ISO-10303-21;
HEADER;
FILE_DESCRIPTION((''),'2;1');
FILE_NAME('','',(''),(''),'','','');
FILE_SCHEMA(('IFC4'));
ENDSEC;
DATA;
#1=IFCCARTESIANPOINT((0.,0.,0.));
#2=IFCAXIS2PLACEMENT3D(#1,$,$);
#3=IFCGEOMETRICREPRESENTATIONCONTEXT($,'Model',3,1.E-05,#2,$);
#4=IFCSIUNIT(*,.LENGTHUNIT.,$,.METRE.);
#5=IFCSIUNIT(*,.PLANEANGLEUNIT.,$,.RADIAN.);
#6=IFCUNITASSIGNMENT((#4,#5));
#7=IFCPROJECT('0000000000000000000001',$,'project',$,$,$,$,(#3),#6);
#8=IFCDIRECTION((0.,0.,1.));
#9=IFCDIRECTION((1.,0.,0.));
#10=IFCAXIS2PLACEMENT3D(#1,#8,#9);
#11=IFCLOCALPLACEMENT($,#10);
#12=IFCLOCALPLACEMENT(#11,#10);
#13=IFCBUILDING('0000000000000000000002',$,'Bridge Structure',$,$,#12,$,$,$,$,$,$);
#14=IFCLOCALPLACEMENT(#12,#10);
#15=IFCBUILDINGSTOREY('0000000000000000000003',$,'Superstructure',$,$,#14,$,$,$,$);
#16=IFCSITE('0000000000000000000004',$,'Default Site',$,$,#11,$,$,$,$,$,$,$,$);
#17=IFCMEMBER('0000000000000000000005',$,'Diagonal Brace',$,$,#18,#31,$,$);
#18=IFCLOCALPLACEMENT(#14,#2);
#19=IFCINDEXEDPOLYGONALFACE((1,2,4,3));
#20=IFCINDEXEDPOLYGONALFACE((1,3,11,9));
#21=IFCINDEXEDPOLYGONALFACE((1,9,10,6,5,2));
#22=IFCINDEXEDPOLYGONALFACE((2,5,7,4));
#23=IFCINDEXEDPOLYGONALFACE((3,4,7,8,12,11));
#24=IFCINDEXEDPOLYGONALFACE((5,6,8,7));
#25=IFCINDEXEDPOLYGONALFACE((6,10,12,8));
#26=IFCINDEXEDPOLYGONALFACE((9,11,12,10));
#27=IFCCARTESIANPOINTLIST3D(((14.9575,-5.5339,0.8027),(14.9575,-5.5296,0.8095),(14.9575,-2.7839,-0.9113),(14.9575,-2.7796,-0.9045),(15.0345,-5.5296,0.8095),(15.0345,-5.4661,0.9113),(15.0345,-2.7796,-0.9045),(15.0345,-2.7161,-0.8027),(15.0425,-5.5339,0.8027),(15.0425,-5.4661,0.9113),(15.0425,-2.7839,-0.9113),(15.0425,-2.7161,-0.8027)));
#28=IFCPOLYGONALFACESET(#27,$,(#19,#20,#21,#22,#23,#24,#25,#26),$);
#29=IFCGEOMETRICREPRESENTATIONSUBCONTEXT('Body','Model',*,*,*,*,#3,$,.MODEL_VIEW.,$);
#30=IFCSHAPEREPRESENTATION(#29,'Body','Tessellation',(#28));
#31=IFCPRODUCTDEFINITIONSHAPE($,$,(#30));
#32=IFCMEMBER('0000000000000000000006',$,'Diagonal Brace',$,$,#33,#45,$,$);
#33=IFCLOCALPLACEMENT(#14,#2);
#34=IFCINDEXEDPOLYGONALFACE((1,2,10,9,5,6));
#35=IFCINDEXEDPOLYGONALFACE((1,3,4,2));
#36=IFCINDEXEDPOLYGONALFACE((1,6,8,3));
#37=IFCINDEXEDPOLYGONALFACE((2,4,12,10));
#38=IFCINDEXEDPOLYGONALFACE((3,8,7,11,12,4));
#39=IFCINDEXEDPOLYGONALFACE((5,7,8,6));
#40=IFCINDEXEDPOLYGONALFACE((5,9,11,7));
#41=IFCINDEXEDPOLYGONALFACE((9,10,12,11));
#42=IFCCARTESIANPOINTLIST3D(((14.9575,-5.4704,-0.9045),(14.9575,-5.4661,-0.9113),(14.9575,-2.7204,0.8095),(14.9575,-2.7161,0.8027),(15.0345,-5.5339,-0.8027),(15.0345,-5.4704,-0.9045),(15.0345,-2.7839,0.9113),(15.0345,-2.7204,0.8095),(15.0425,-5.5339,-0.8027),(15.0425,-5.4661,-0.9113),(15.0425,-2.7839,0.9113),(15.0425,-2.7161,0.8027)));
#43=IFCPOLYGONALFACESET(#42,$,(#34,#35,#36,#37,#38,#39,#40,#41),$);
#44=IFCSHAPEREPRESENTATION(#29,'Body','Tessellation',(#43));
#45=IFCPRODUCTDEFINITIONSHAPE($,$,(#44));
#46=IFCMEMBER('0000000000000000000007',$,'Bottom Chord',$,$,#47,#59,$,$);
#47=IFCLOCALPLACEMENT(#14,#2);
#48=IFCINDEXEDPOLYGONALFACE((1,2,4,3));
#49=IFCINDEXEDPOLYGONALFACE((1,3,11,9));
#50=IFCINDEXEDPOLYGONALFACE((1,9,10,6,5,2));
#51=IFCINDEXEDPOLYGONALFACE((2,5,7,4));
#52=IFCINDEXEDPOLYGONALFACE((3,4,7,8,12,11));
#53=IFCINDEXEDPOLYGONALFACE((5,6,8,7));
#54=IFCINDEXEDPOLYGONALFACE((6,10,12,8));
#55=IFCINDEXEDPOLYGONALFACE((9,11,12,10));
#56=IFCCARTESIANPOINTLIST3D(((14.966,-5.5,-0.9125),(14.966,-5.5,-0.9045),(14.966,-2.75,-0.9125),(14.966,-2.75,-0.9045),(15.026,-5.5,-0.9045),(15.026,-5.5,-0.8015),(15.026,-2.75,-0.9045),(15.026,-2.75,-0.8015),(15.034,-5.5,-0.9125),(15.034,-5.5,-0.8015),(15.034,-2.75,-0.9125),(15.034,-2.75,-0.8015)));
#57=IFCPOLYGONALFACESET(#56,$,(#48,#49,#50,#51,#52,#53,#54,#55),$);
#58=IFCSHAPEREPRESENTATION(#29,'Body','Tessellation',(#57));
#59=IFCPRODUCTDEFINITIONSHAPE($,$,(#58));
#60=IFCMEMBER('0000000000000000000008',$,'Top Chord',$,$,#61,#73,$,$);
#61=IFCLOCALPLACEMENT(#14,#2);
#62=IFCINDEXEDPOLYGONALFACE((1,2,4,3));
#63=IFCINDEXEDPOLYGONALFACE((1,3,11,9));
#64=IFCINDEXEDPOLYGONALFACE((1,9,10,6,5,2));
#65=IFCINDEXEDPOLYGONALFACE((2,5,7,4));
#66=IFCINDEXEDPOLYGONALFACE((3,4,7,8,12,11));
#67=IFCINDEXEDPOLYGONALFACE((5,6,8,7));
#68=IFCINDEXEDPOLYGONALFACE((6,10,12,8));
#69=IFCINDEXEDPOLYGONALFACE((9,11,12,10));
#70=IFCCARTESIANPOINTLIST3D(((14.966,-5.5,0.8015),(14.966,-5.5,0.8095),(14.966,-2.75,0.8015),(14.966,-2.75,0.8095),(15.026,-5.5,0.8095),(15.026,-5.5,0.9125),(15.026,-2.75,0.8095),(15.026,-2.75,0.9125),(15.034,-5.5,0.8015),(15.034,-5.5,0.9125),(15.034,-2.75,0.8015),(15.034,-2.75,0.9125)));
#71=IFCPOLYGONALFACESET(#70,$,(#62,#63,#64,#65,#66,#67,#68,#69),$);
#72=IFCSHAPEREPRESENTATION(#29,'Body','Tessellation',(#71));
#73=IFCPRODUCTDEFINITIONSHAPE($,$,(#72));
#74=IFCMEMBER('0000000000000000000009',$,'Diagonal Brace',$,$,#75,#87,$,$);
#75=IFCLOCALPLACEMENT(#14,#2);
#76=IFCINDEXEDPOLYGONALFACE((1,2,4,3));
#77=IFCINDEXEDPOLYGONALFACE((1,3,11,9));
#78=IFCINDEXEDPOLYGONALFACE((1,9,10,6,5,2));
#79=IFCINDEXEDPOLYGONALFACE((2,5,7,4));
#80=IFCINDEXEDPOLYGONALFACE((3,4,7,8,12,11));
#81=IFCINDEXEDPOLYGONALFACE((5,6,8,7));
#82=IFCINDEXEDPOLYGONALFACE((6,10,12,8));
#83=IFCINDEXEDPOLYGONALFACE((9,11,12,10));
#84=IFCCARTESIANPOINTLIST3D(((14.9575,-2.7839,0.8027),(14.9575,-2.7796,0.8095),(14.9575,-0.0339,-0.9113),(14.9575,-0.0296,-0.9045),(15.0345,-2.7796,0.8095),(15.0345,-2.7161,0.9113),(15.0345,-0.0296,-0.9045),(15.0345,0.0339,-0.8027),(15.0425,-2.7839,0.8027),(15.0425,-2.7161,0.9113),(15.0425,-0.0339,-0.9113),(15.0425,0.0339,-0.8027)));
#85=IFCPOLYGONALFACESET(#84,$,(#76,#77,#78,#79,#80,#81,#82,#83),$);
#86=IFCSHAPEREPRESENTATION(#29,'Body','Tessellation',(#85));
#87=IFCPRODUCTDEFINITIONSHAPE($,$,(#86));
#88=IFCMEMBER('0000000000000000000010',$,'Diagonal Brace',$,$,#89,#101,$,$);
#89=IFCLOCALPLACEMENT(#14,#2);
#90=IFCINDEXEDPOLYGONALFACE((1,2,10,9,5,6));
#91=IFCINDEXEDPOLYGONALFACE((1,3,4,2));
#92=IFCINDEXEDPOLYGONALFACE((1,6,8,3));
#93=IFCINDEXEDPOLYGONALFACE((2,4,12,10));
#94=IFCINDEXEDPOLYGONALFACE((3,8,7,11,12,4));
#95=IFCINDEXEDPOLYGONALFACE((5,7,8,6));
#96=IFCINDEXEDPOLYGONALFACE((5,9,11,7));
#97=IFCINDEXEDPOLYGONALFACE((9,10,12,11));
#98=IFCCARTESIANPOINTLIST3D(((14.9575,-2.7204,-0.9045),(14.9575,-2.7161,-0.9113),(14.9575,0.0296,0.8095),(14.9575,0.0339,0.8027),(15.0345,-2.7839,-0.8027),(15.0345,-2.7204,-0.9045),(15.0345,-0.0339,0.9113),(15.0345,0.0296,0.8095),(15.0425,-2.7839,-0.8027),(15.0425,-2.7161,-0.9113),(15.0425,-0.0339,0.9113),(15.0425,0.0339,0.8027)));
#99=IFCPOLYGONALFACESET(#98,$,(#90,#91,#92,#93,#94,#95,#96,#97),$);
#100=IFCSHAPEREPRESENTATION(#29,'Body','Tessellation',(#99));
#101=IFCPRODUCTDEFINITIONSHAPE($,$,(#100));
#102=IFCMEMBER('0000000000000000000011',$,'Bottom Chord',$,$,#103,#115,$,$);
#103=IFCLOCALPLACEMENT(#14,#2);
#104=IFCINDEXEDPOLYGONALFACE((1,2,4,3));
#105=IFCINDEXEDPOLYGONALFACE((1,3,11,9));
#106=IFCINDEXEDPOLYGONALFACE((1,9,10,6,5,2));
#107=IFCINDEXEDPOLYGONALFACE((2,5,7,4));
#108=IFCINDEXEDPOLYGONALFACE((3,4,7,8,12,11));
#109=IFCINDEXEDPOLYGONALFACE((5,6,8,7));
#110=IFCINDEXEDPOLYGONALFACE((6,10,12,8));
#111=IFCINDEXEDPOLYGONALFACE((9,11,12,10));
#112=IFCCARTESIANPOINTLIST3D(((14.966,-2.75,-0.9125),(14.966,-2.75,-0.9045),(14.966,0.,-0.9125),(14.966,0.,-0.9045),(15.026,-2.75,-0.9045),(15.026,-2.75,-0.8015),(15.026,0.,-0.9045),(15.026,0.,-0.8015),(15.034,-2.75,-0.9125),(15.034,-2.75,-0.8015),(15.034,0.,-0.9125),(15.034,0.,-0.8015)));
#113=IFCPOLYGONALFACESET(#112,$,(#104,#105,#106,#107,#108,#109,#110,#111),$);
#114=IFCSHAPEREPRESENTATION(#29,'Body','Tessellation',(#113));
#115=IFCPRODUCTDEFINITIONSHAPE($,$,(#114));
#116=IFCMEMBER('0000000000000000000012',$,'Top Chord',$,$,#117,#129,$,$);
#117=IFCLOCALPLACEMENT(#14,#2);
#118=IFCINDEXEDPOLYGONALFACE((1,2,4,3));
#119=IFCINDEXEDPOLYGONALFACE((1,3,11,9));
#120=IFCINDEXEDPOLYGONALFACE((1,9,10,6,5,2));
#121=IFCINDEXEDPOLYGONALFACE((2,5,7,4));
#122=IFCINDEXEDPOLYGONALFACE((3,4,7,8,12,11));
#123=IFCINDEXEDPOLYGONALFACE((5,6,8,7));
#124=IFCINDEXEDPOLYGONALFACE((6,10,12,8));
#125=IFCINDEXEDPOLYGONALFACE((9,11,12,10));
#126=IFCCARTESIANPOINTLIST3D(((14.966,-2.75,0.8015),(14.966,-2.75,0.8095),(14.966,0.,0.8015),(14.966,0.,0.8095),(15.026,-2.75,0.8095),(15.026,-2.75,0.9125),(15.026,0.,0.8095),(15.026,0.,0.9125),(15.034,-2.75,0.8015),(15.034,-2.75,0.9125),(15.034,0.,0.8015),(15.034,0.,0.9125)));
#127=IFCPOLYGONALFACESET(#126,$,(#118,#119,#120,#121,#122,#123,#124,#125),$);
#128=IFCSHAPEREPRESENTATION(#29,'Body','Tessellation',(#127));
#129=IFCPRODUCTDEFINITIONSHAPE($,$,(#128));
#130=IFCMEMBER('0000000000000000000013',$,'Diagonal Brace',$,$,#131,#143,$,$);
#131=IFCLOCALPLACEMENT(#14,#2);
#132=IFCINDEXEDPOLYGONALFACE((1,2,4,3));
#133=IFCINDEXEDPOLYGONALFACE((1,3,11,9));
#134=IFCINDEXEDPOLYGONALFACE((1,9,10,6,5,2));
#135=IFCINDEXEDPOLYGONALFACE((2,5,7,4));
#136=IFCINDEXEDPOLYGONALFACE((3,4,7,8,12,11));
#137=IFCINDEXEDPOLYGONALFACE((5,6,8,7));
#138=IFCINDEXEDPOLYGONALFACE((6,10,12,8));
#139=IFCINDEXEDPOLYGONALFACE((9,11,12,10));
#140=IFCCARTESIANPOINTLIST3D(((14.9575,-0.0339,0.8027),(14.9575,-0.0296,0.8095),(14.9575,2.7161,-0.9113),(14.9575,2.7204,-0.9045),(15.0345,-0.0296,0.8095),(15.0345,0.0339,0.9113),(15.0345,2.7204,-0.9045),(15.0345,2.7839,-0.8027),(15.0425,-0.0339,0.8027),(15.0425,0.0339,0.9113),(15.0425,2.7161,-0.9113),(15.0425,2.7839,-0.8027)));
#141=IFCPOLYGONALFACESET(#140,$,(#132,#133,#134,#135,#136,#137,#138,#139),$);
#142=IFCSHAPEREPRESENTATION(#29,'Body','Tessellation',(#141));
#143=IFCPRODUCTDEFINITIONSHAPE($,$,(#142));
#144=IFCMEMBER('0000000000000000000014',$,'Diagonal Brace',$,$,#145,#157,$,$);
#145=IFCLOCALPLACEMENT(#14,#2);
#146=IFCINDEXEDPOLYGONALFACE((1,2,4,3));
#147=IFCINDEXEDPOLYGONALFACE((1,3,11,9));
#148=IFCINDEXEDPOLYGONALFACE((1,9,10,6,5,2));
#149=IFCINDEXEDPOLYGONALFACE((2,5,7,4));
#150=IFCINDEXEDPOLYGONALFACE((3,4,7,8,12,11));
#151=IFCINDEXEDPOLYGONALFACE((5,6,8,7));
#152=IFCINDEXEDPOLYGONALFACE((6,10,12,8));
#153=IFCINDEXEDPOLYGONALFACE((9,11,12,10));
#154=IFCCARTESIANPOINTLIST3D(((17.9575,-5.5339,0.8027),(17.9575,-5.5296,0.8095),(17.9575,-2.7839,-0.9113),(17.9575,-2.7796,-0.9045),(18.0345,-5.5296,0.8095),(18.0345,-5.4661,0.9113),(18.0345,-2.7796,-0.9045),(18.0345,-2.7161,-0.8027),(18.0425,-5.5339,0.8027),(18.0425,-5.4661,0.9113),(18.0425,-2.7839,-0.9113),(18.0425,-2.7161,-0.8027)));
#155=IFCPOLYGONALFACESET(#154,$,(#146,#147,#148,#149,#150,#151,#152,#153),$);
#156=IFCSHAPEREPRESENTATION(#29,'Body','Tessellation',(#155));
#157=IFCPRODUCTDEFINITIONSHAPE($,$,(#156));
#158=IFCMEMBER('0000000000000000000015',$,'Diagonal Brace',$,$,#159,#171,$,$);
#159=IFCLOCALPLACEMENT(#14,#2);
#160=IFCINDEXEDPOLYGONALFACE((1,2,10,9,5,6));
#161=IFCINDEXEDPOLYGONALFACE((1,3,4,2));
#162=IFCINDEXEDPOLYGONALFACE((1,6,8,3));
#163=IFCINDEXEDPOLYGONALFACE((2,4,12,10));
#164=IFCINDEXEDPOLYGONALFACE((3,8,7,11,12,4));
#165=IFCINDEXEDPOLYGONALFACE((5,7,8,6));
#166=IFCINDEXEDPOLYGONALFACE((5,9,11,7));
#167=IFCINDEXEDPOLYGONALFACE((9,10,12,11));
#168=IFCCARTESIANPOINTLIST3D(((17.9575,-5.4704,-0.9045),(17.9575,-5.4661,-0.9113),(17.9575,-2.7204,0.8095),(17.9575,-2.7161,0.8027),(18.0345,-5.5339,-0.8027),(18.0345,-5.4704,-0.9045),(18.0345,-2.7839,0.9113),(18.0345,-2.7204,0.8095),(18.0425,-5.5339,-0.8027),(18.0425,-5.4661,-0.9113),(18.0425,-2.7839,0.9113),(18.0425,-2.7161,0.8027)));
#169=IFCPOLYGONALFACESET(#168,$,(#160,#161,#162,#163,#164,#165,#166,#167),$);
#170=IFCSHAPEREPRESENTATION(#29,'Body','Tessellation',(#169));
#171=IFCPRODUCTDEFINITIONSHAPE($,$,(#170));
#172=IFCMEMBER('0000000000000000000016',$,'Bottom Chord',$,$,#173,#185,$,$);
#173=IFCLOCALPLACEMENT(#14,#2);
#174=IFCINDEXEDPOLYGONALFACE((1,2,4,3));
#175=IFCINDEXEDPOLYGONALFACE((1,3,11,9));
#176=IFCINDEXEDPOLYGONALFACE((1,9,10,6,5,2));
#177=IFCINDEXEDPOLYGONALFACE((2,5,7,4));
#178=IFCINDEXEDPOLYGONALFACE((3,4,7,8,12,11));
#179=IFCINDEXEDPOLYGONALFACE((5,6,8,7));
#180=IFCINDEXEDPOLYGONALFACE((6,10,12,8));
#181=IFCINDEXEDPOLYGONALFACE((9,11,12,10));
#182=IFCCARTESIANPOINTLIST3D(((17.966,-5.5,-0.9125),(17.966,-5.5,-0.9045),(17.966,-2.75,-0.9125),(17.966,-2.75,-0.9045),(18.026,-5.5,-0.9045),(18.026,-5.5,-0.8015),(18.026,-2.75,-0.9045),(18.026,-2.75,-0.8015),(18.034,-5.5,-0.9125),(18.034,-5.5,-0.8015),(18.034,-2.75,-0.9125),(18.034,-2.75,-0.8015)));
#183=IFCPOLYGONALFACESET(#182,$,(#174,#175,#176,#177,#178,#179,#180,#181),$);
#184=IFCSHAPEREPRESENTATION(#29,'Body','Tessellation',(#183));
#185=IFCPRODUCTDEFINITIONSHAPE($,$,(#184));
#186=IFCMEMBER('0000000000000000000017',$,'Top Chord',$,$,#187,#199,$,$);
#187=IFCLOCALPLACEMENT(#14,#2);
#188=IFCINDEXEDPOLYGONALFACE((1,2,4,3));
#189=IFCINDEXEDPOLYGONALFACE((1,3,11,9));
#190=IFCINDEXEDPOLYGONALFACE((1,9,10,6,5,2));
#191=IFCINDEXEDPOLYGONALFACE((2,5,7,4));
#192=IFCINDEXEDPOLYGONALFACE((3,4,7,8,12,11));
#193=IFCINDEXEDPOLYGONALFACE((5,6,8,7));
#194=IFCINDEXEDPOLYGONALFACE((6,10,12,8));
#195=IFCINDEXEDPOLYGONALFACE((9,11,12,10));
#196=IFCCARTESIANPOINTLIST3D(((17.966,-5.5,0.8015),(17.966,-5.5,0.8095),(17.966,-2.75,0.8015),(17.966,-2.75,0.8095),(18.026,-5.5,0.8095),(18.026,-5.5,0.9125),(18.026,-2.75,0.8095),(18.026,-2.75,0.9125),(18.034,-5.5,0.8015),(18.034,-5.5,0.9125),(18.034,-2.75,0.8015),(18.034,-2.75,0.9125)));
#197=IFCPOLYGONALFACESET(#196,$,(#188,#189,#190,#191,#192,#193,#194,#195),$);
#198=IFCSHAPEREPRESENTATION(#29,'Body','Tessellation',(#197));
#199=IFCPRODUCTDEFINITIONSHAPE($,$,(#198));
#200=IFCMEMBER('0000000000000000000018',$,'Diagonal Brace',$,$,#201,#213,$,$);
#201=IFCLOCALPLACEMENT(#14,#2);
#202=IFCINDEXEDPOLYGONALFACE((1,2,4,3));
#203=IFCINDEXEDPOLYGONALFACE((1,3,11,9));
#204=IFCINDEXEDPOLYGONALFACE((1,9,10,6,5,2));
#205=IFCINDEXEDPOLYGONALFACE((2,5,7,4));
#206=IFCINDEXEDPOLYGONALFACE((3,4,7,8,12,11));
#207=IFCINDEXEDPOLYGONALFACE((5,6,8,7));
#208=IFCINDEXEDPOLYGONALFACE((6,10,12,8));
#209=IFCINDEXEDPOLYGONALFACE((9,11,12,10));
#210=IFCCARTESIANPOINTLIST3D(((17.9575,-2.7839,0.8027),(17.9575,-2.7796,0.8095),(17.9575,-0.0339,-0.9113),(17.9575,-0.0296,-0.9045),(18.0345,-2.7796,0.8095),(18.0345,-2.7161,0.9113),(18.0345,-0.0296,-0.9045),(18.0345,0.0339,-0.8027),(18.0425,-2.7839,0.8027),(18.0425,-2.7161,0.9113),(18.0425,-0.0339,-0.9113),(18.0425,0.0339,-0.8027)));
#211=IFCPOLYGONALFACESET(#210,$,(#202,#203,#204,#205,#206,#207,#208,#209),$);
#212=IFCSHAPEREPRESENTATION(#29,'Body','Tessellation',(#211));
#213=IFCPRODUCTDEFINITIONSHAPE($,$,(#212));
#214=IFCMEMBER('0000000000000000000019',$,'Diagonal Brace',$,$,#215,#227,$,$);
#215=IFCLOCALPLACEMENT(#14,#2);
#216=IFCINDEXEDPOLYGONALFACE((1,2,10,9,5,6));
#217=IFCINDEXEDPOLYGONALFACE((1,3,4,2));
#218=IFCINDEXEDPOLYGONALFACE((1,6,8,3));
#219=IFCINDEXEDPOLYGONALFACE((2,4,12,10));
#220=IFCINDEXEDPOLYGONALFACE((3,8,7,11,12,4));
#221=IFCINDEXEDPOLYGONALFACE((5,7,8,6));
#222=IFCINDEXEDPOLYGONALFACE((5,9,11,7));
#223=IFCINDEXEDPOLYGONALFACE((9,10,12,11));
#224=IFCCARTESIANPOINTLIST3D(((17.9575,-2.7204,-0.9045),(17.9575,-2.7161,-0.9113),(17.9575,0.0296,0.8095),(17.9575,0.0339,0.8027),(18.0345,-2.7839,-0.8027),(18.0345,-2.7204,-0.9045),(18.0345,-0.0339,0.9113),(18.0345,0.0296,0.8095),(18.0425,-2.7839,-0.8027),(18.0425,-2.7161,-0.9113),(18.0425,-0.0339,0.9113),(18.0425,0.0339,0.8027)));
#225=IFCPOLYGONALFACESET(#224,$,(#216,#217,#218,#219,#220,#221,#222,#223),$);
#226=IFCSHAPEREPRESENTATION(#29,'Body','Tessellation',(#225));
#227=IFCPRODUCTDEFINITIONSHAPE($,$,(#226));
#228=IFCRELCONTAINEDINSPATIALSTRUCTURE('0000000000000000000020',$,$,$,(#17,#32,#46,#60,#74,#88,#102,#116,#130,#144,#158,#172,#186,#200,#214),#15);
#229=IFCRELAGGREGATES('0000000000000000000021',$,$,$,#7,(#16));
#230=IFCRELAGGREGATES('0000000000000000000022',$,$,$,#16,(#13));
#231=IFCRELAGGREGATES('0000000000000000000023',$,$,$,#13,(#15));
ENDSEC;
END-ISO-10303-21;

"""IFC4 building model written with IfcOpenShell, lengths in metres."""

from ifc_helpers import new_model, si_unit, frame, origin, origin_with_axes, origin_2d_with_axis, place, context, subcontext, project, spatial, l_section, extrude, element, save


model = new_model("IFC4")

# Units and contexts
model_context = context("Model", 3, precision=1e-05, world=origin())
body_context = subcontext(model_context, "Body", "Model", "MODEL_VIEW")
ifc_project = project(units=[si_unit("LENGTHUNIT", "METRE"), si_unit("PLANEANGLEUNIT", "RADIAN")], contexts=[model_context])

# Site, building, storey
site_placement = place(None, origin_with_axes())
site = spatial("IfcSite", under=ifc_project, at=site_placement, Name="Default Site")
building_placement = place(site_placement, origin_with_axes())
building = spatial("IfcBuilding", under=site, at=building_placement, Name="Bridge Structure")
storey_placement = place(building_placement, origin_with_axes())
storey = spatial("IfcBuildingStorey", under=building, at=storey_placement, Name="Superstructure")

# Members
for number, where, z_axis, x_axis, name in (
    (1, (15.0, -5.5, 0.857), (0.0, 0.848656, -0.528944), (-1.0, 0.0, 0.0), "Diagonal Brace"),
    (2, (15.0, -5.5, -0.857), (0.0, 0.848656, 0.528944), (-1.0, 0.0, 0.0), "Diagonal Brace"),
):
    element("IfcMember", number, at=place(storey_placement, frame(where, z_axis=z_axis, x_axis=x_axis)), inside=storey, Name=name, context=body_context, shape_type="SweptSolid", body=[
        extrude(l_section(Depth=0.128, Width=0.085, Thickness=0.008, at=origin_2d_with_axis()), origin_with_axes(), (0.0, 0.0, 1.0), 3.2404),
    ])
for number, where, z_axis, x_axis, name in (
    (3, (15.0, -5.5, -0.857), (0.0, 1.0, 0.0), (-1.0, 0.0, 0.0), "Bottom Chord"),
    (4, (15.0, -5.5, 0.857), (0.0, 1.0, 0.0), (-1.0, 0.0, 0.0), "Top Chord"),
):
    element("IfcMember", number, at=place(storey_placement, frame(where, z_axis=z_axis, x_axis=x_axis)), inside=storey, Name=name, context=body_context, shape_type="SweptSolid", body=[
        extrude(l_section(Depth=0.111, Width=0.068, Thickness=0.008, at=origin_2d_with_axis()), origin_with_axes(), (0.0, 0.0, 1.0), 2.75),
    ])
for number, where, z_axis, x_axis, name in (
    (5, (15.0, -2.75, 0.857), (0.0, 0.848656, -0.528944), (-1.0, 0.0, 0.0), "Diagonal Brace"),
    (6, (15.0, -2.75, -0.857), (0.0, 0.848656, 0.528944), (-1.0, 0.0, 0.0), "Diagonal Brace"),
):
    element("IfcMember", number, at=place(storey_placement, frame(where, z_axis=z_axis, x_axis=x_axis)), inside=storey, Name=name, context=body_context, shape_type="SweptSolid", body=[
        extrude(l_section(Depth=0.128, Width=0.085, Thickness=0.008, at=origin_2d_with_axis()), origin_with_axes(), (0.0, 0.0, 1.0), 3.2404),
    ])
for number, where, z_axis, x_axis, name in (
    (7, (15.0, -2.75, -0.857), (0.0, 1.0, 0.0), (-1.0, 0.0, 0.0), "Bottom Chord"),
    (8, (15.0, -2.75, 0.857), (0.0, 1.0, 0.0), (-1.0, 0.0, 0.0), "Top Chord"),
):
    element("IfcMember", number, at=place(storey_placement, frame(where, z_axis=z_axis, x_axis=x_axis)), inside=storey, Name=name, context=body_context, shape_type="SweptSolid", body=[
        extrude(l_section(Depth=0.111, Width=0.068, Thickness=0.008, at=origin_2d_with_axis()), origin_with_axes(), (0.0, 0.0, 1.0), 2.75),
    ])
for number, where, z_axis, x_axis, name in (
    (9, (15.0, 0.0, 0.857), (0.0, 0.848656, -0.528944), (-1.0, 0.0, 0.0), "Diagonal Brace"),
    (10, (18.0, -5.5, 0.857), (0.0, 0.848656, -0.528944), (-1.0, 0.0, 0.0), "Diagonal Brace"),
    (11, (18.0, -5.5, -0.857), (0.0, 0.848656, 0.528944), (-1.0, 0.0, 0.0), "Diagonal Brace"),
):
    element("IfcMember", number, at=place(storey_placement, frame(where, z_axis=z_axis, x_axis=x_axis)), inside=storey, Name=name, context=body_context, shape_type="SweptSolid", body=[
        extrude(l_section(Depth=0.128, Width=0.085, Thickness=0.008, at=origin_2d_with_axis()), origin_with_axes(), (0.0, 0.0, 1.0), 3.2404),
    ])
for number, where, z_axis, x_axis, name in (
    (12, (18.0, -5.5, -0.857), (0.0, 1.0, 0.0), (-1.0, 0.0, 0.0), "Bottom Chord"),
    (13, (18.0, -5.5, 0.857), (0.0, 1.0, 0.0), (-1.0, 0.0, 0.0), "Top Chord"),
):
    element("IfcMember", number, at=place(storey_placement, frame(where, z_axis=z_axis, x_axis=x_axis)), inside=storey, Name=name, context=body_context, shape_type="SweptSolid", body=[
        extrude(l_section(Depth=0.111, Width=0.068, Thickness=0.008, at=origin_2d_with_axis()), origin_with_axes(), (0.0, 0.0, 1.0), 2.75),
    ])
for number, where, z_axis, x_axis, name in (
    (14, (18.0, -2.75, 0.857), (0.0, 0.848656, -0.528944), (-1.0, 0.0, 0.0), "Diagonal Brace"),
    (15, (18.0, -2.75, -0.857), (0.0, 0.848656, 0.528944), (-1.0, 0.0, 0.0), "Diagonal Brace"),
):
    element("IfcMember", number, at=place(storey_placement, frame(where, z_axis=z_axis, x_axis=x_axis)), inside=storey, Name=name, context=body_context, shape_type="SweptSolid", body=[
        extrude(l_section(Depth=0.128, Width=0.085, Thickness=0.008, at=origin_2d_with_axis()), origin_with_axes(), (0.0, 0.0, 1.0), 3.2404),
    ])

save(model, "model.ifc")
